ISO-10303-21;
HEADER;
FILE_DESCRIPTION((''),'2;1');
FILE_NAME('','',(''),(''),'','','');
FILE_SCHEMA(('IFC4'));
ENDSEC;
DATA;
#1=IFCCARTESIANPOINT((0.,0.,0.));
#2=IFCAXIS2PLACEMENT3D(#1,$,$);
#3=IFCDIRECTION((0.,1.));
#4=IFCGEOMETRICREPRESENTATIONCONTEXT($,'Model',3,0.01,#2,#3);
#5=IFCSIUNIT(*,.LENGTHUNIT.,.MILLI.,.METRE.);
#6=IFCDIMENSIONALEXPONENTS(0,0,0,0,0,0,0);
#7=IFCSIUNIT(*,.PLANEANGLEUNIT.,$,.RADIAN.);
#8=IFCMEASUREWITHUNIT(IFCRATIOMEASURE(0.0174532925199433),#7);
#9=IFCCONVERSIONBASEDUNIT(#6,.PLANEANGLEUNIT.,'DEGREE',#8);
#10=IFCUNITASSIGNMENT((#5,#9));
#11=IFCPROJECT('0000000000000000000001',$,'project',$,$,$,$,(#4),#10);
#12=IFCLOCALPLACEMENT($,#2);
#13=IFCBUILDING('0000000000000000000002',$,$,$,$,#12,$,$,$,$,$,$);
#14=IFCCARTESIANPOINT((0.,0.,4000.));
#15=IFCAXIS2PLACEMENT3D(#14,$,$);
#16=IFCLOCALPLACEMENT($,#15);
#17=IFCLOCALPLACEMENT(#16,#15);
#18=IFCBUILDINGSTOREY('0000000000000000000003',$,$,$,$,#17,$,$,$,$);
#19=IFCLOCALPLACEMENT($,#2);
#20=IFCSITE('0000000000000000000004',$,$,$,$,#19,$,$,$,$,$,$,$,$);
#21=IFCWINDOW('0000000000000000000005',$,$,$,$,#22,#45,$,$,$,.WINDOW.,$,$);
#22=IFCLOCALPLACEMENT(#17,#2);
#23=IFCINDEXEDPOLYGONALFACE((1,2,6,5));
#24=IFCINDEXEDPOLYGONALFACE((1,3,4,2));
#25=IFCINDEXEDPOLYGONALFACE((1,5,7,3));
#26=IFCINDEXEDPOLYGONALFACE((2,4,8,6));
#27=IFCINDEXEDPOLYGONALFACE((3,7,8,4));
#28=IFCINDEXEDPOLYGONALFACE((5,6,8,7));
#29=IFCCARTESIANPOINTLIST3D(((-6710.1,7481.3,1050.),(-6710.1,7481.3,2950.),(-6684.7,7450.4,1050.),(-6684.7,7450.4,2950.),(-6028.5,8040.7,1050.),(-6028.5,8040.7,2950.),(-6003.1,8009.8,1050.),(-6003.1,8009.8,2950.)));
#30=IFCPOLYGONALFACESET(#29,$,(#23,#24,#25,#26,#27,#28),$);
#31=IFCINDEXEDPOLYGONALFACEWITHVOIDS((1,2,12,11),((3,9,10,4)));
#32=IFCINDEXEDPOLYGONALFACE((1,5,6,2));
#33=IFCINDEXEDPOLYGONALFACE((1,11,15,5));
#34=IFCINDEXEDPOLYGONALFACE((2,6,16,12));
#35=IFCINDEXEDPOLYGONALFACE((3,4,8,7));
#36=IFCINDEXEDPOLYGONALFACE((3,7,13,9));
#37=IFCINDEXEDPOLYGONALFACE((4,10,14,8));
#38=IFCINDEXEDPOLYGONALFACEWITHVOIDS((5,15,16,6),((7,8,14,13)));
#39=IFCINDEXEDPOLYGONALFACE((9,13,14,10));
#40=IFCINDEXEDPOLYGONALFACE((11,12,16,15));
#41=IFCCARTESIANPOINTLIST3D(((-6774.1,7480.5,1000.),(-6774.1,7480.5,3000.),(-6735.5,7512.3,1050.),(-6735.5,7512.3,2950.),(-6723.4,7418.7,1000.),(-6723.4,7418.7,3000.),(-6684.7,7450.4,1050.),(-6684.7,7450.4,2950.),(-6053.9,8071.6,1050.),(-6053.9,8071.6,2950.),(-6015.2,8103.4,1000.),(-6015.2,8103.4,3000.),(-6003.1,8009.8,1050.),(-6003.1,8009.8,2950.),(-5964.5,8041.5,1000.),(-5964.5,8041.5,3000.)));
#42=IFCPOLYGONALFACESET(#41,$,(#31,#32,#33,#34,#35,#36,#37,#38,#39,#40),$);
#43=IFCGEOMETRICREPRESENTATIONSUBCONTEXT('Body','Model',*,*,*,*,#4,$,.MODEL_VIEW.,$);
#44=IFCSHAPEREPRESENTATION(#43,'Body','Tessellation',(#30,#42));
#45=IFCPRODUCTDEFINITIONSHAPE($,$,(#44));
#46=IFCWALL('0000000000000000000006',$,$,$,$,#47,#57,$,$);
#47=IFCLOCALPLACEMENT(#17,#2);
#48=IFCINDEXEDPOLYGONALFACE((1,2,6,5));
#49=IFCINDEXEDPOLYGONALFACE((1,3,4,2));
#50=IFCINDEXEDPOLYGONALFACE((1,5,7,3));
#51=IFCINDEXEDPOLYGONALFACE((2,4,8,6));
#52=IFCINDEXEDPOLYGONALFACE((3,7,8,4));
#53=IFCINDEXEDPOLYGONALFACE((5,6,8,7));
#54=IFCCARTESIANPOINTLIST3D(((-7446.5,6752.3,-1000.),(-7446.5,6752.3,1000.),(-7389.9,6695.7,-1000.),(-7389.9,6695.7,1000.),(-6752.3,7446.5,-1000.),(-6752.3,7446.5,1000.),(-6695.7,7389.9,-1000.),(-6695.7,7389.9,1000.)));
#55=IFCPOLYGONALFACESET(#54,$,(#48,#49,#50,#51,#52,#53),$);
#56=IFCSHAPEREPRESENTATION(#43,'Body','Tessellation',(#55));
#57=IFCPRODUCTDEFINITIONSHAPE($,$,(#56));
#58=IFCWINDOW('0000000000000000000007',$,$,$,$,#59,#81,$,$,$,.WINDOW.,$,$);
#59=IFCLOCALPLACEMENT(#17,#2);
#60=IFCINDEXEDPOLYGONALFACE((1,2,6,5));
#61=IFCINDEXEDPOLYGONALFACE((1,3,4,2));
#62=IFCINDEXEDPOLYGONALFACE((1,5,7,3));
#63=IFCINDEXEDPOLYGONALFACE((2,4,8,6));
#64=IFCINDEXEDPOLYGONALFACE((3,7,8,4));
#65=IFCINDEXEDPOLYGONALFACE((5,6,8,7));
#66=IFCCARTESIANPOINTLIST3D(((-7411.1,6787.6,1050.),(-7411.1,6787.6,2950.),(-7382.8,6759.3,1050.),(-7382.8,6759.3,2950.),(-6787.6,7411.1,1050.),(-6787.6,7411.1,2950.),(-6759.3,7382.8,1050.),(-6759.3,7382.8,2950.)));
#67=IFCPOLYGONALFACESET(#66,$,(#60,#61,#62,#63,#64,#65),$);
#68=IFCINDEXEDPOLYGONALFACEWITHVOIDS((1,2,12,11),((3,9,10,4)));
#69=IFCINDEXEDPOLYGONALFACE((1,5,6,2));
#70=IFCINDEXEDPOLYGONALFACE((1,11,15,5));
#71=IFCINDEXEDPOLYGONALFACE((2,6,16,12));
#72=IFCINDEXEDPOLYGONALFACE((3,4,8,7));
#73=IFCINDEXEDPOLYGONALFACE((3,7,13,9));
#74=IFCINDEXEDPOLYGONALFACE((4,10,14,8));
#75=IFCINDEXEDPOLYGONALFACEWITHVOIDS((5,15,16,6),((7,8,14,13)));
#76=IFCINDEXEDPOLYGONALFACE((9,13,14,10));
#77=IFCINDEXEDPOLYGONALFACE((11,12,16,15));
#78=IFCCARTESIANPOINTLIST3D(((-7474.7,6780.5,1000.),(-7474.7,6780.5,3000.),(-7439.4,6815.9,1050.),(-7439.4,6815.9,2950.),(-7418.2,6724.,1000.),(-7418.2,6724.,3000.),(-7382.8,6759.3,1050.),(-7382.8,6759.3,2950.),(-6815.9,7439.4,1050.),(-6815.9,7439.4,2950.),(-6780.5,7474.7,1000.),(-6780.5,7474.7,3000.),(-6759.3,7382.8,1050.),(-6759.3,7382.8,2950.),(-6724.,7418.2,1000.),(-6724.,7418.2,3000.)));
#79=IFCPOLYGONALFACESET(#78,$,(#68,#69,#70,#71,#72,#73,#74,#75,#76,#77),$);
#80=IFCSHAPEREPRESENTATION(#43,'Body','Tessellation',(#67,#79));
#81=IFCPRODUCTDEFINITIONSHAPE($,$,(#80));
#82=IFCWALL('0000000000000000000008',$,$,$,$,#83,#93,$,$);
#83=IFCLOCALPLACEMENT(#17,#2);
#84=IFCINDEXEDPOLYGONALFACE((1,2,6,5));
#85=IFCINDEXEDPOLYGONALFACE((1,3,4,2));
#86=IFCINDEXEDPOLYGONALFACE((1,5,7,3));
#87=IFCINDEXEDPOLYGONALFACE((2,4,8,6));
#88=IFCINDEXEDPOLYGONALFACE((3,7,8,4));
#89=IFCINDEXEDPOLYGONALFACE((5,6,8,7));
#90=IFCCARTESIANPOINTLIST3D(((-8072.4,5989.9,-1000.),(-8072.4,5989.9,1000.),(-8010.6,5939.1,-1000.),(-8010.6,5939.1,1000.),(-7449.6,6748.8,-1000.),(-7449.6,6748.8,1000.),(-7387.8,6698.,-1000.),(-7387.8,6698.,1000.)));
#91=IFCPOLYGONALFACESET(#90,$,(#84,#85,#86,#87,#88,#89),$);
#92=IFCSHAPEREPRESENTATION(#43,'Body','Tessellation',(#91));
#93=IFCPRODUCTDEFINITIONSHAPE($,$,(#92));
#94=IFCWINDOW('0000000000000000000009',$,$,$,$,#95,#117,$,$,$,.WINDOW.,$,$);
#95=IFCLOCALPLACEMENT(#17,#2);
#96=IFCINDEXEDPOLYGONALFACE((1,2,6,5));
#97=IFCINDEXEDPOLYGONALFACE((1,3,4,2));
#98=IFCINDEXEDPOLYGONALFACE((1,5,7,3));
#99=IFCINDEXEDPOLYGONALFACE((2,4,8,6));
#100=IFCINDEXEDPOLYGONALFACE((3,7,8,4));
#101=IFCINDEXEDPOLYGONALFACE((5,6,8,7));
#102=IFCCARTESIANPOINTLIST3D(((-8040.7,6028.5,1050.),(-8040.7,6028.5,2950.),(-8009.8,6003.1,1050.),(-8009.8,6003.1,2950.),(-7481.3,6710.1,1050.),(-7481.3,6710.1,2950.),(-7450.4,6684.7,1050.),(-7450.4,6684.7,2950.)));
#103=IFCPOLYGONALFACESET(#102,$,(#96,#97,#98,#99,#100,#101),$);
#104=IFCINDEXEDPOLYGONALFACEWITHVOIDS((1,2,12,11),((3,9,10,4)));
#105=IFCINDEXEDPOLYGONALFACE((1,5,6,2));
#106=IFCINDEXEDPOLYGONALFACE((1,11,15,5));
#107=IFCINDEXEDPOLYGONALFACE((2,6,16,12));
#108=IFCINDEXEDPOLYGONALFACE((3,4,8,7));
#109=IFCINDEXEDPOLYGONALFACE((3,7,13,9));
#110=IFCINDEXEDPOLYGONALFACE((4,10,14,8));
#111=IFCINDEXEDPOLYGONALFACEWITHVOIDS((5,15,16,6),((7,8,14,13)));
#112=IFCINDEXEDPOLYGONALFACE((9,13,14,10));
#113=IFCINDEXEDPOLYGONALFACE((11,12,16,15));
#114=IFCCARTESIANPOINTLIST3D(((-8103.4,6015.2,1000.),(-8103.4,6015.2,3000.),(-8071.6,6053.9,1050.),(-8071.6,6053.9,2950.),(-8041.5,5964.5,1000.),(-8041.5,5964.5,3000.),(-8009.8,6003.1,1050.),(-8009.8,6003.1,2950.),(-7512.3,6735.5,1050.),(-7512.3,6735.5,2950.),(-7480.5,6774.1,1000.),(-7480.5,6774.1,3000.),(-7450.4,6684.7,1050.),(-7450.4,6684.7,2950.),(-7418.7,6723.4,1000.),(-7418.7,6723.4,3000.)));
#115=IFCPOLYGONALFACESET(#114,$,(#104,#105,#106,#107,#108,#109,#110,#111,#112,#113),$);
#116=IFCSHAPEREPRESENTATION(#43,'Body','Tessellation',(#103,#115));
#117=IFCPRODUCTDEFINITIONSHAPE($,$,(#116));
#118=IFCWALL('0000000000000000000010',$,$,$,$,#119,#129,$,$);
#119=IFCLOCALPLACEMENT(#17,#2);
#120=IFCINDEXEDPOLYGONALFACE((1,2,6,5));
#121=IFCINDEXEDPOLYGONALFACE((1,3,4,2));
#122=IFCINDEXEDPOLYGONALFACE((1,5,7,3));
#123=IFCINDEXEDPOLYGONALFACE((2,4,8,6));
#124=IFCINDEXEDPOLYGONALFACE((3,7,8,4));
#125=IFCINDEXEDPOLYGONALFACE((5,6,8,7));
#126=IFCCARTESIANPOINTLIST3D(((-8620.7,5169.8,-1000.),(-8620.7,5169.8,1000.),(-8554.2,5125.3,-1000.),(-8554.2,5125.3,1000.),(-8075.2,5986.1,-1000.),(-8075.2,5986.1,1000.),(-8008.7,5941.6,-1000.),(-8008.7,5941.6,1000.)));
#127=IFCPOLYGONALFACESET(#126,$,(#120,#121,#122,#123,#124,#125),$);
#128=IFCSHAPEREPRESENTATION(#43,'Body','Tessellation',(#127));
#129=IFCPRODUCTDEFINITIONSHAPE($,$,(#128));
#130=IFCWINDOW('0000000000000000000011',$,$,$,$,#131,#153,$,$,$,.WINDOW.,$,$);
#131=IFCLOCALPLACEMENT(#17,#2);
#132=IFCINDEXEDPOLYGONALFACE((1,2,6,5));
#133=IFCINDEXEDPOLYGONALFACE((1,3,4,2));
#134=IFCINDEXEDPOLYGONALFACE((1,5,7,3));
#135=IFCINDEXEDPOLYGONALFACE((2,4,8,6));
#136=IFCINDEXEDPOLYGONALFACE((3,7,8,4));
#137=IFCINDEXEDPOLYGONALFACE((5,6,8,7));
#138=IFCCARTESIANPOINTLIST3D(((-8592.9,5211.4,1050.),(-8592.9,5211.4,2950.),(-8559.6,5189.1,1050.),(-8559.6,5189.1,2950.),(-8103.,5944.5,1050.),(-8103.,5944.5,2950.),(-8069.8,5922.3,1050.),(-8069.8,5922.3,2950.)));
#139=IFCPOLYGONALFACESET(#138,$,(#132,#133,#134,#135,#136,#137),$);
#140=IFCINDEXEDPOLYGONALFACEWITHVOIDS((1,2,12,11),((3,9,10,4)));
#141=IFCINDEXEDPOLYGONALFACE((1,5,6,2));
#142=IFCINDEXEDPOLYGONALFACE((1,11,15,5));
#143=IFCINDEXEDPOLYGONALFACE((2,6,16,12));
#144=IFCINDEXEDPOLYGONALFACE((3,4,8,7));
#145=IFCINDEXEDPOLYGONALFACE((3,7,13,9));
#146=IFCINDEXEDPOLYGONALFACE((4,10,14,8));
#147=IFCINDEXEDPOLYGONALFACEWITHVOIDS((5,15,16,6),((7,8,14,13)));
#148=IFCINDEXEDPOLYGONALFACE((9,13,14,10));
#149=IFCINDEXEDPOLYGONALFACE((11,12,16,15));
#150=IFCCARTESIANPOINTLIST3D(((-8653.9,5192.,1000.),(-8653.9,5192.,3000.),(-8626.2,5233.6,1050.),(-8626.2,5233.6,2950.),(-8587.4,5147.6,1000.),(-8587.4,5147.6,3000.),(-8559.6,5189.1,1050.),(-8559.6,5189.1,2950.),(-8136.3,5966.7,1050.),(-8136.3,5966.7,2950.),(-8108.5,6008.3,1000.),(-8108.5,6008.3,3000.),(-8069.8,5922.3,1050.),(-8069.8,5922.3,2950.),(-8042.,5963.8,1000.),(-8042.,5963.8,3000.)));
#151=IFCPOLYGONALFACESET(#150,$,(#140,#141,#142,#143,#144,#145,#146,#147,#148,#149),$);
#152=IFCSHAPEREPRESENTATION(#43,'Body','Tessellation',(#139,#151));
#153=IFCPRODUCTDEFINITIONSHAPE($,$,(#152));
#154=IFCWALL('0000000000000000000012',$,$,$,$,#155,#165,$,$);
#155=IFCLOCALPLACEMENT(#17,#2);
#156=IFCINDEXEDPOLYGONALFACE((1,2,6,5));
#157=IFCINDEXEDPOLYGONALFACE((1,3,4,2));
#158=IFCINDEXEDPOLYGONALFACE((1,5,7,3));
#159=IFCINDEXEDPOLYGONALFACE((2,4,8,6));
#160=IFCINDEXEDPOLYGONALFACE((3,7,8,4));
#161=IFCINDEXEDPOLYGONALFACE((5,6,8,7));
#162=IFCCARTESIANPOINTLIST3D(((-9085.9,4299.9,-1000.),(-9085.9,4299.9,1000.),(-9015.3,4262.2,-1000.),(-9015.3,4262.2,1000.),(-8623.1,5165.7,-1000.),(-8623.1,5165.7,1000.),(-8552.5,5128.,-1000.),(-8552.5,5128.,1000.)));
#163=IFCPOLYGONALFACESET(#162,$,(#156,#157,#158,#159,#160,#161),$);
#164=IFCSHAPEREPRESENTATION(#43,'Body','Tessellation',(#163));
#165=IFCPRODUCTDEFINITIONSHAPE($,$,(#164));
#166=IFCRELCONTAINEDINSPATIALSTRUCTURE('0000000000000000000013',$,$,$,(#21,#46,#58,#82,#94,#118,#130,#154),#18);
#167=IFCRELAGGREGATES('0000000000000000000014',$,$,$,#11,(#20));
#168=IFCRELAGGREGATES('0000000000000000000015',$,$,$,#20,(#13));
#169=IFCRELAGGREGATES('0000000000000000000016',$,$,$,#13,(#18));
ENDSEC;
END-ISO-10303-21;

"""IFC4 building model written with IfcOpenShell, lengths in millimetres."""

from ifc_helpers import new_model, entity, si_unit, converted_unit, direction, frame, origin, origin_2d, place, context, subcontext, project, spatial, rectangle, extrude, element, save


model = new_model("IFC4")

# Units and contexts
model_context = context("Model", 3, precision=0.01, world=origin(), true_north=direction((0.0, 1.0)))
body_context = subcontext(model_context, "Body", "Model", "MODEL_VIEW")
ifc_project = project(units=[si_unit("LENGTHUNIT", "METRE", prefix="MILLI"), converted_unit("PLANEANGLEUNIT", "DEGREE", entity("IfcRatioMeasure", 0.0174532925199433), si_unit("PLANEANGLEUNIT", "RADIAN"), dimensions=[0, 0, 0, 0, 0, 0, 0])], contexts=[model_context])

# Site, building, storey
site_placement = place(None, origin())
site = spatial("IfcSite", under=ifc_project, at=site_placement)
building_placement = place(None, origin())
building = spatial("IfcBuilding", under=site, at=building_placement)
placement = place(None, frame((0.0, 0.0, 4000.0)))
storey_placement = place(placement, frame((0.0, 0.0, 4000.0)))
storey = spatial("IfcBuildingStorey", under=building, at=storey_placement)

# Shared definitions
cartesian_point_1 = entity("IfcCartesianPoint", [-440.9, -950.0])
shared_polyline = entity("IfcPolyline", [cartesian_point_1, entity("IfcCartesianPoint", [-440.9, 950.0]), entity("IfcCartesianPoint", [-440.9, 950.0]), entity("IfcCartesianPoint", [440.9, 950.0]), entity("IfcCartesianPoint", [440.9, 950.0]), entity("IfcCartesianPoint", [440.9, -950.0]), entity("IfcCartesianPoint", [440.9, -950.0]), entity("IfcCartesianPoint", [-440.9, -950.0]), cartesian_point_1])

# Window
window_1_placement = place(storey_placement, frame((-6343.9, 7730.1, 2000.0), z_axis=(0.0, 0.0, 1.0), x_axis=(-7730.104749, -6343.932579, 0.0)))
cartesian_point_2 = entity("IfcCartesianPoint", [-490.9, -1000.0])
element("IfcWindow", 1, at=window_1_placement, inside=storey, PredefinedType="WINDOW", context=body_context, shape_type="SweptSolid", body=[
    entity("IfcExtrudedAreaSolid", entity("IfcArbitraryClosedProfileDef", "AREA", None, shared_polyline), entity("IfcAxis2Placement3D", entity("IfcCartesianPoint", [0.0, 0.0, 0.0]), entity("IfcDirection", [0.0, -1.0, 0.0]), entity("IfcDirection", [1.0, 0.0, 0.0])), entity("IfcDirection", [0.0, 0.0, 1.0]), 40.0),
    entity("IfcExtrudedAreaSolid", entity("IfcArbitraryProfileDefWithVoids", "AREA", None, entity("IfcPolyline", [cartesian_point_2, entity("IfcCartesianPoint", [-490.9, 1000.0]), entity("IfcCartesianPoint", [-490.9, 1000.0]), entity("IfcCartesianPoint", [490.9, 1000.0]), entity("IfcCartesianPoint", [490.9, 1000.0]), entity("IfcCartesianPoint", [490.9, -1000.0]), entity("IfcCartesianPoint", [490.9, -1000.0]), entity("IfcCartesianPoint", [-490.9, -1000.0]), cartesian_point_2]), [shared_polyline]), entity("IfcAxis2Placement3D", entity("IfcCartesianPoint", [0.0, 0.0, 0.0]), entity("IfcDirection", [0.0, -1.0, 0.0]), entity("IfcDirection", [1.0, 0.0, 0.0])), entity("IfcDirection", [0.0, 0.0, 1.0]), 80.0),
])

# Wall
wall_1_placement = place(storey_placement, frame((-7071.1, 7071.1, -1000.0), z_axis=(0.0, 0.0, 1.0), x_axis=(-7071.06777, -7071.067854, 0.0)))
element("IfcWall", 2, at=wall_1_placement, inside=storey, context=body_context, shape_type="SweptSolid", body=[
    extrude(rectangle(XDim=981.7, YDim=80.0, at=origin_2d()), origin(), (0.0, 0.0, 1.0), 2000.0),
])

# Window
window_2_placement = place(storey_placement, frame((-7071.1, 7071.1, 2000.0), z_axis=(0.0, 0.0, 1.0), x_axis=(-7071.06777, -7071.067854, 0.0)))
cartesian_point_3 = entity("IfcCartesianPoint", [-490.9, -1000.0])
element("IfcWindow", 3, at=window_2_placement, inside=storey, PredefinedType="WINDOW", context=body_context, shape_type="SweptSolid", body=[
    entity("IfcExtrudedAreaSolid", entity("IfcArbitraryClosedProfileDef", "AREA", None, shared_polyline), entity("IfcAxis2Placement3D", entity("IfcCartesianPoint", [0.0, 0.0, 0.0]), entity("IfcDirection", [0.0, -1.0, 0.0]), entity("IfcDirection", [1.0, 0.0, 0.0])), entity("IfcDirection", [0.0, 0.0, 1.0]), 40.0),
    entity("IfcExtrudedAreaSolid", entity("IfcArbitraryProfileDefWithVoids", "AREA", None, entity("IfcPolyline", [cartesian_point_3, entity("IfcCartesianPoint", [-490.9, 1000.0]), entity("IfcCartesianPoint", [-490.9, 1000.0]), entity("IfcCartesianPoint", [490.9, 1000.0]), entity("IfcCartesianPoint", [490.9, 1000.0]), entity("IfcCartesianPoint", [490.9, -1000.0]), entity("IfcCartesianPoint", [490.9, -1000.0]), entity("IfcCartesianPoint", [-490.9, -1000.0]), cartesian_point_3]), [shared_polyline]), entity("IfcAxis2Placement3D", entity("IfcCartesianPoint", [0.0, 0.0, 0.0]), entity("IfcDirection", [0.0, -1.0, 0.0]), entity("IfcDirection", [1.0, 0.0, 0.0])), entity("IfcDirection", [0.0, 0.0, 1.0]), 80.0),
])

# Wall
wall_2_placement = place(storey_placement, frame((-7730.1, 6343.9, -1000.0), z_axis=(0.0, 0.0, 1.0), x_axis=(-6343.932486, -7730.104825, 0.0)))
element("IfcWall", 4, at=wall_2_placement, inside=storey, context=body_context, shape_type="SweptSolid", body=[
    extrude(rectangle(XDim=981.7, YDim=80.0, at=origin_2d()), origin(), (0.0, 0.0, 1.0), 2000.0),
])

# Window
window_3_placement = place(storey_placement, frame((-7730.1, 6343.9, 2000.0), z_axis=(0.0, 0.0, 1.0), x_axis=(-6343.932486, -7730.104825, 0.0)))
cartesian_point_4 = entity("IfcCartesianPoint", [-490.9, -1000.0])
element("IfcWindow", 5, at=window_3_placement, inside=storey, PredefinedType="WINDOW", context=body_context, shape_type="SweptSolid", body=[
    entity("IfcExtrudedAreaSolid", entity("IfcArbitraryClosedProfileDef", "AREA", None, shared_polyline), entity("IfcAxis2Placement3D", entity("IfcCartesianPoint", [0.0, 0.0, 0.0]), entity("IfcDirection", [0.0, -1.0, 0.0]), entity("IfcDirection", [1.0, 0.0, 0.0])), entity("IfcDirection", [0.0, 0.0, 1.0]), 40.0),
    entity("IfcExtrudedAreaSolid", entity("IfcArbitraryProfileDefWithVoids", "AREA", None, entity("IfcPolyline", [cartesian_point_4, entity("IfcCartesianPoint", [-490.9, 1000.0]), entity("IfcCartesianPoint", [-490.9, 1000.0]), entity("IfcCartesianPoint", [490.9, 1000.0]), entity("IfcCartesianPoint", [490.9, 1000.0]), entity("IfcCartesianPoint", [490.9, -1000.0]), entity("IfcCartesianPoint", [490.9, -1000.0]), entity("IfcCartesianPoint", [-490.9, -1000.0]), cartesian_point_4]), [shared_polyline]), entity("IfcAxis2Placement3D", entity("IfcCartesianPoint", [0.0, 0.0, 0.0]), entity("IfcDirection", [0.0, -1.0, 0.0]), entity("IfcDirection", [1.0, 0.0, 0.0])), entity("IfcDirection", [0.0, 0.0, 1.0]), 80.0),
])

# Wall
wall_3_placement = place(storey_placement, frame((-8314.7, 5555.7, -1000.0), z_axis=(0.0, 0.0, 1.0), x_axis=(-5555.701616, -8314.6966, 0.0)))
element("IfcWall", 6, at=wall_3_placement, inside=storey, context=body_context, shape_type="SweptSolid", body=[
    extrude(rectangle(XDim=981.7, YDim=80.0, at=origin_2d()), origin(), (0.0, 0.0, 1.0), 2000.0),
])

# Window
window_4_placement = place(storey_placement, frame((-8314.7, 5555.7, 2000.0), z_axis=(0.0, 0.0, 1.0), x_axis=(-5555.701616, -8314.6966, 0.0)))
cartesian_point_5 = entity("IfcCartesianPoint", [-490.9, -1000.0])
element("IfcWindow", 7, at=window_4_placement, inside=storey, PredefinedType="WINDOW", context=body_context, shape_type="SweptSolid", body=[
    entity("IfcExtrudedAreaSolid", entity("IfcArbitraryClosedProfileDef", "AREA", None, shared_polyline), entity("IfcAxis2Placement3D", entity("IfcCartesianPoint", [0.0, 0.0, 0.0]), entity("IfcDirection", [0.0, -1.0, 0.0]), entity("IfcDirection", [1.0, 0.0, 0.0])), entity("IfcDirection", [0.0, 0.0, 1.0]), 40.0),
    entity("IfcExtrudedAreaSolid", entity("IfcArbitraryProfileDefWithVoids", "AREA", None, entity("IfcPolyline", [cartesian_point_5, entity("IfcCartesianPoint", [-490.9, 1000.0]), entity("IfcCartesianPoint", [-490.9, 1000.0]), entity("IfcCartesianPoint", [490.9, 1000.0]), entity("IfcCartesianPoint", [490.9, 1000.0]), entity("IfcCartesianPoint", [490.9, -1000.0]), entity("IfcCartesianPoint", [490.9, -1000.0]), entity("IfcCartesianPoint", [-490.9, -1000.0]), cartesian_point_5]), [shared_polyline]), entity("IfcAxis2Placement3D", entity("IfcCartesianPoint", [0.0, 0.0, 0.0]), entity("IfcDirection", [0.0, -1.0, 0.0]), entity("IfcDirection", [1.0, 0.0, 0.0])), entity("IfcDirection", [0.0, 0.0, 1.0]), 80.0),
])

# Wall
wall_4_placement = place(storey_placement, frame((-8819.2, 4714.0, -1000.0), z_axis=(0.0, 0.0, 1.0), x_axis=(-4713.96836, -8819.212113, 0.0)))
element("IfcWall", 8, at=wall_4_placement, inside=storey, context=body_context, shape_type="SweptSolid", body=[
    extrude(rectangle(XDim=981.7, YDim=80.0, at=origin_2d()), origin(), (0.0, 0.0, 1.0), 2000.0),
])

save(model, "model.ifc")
